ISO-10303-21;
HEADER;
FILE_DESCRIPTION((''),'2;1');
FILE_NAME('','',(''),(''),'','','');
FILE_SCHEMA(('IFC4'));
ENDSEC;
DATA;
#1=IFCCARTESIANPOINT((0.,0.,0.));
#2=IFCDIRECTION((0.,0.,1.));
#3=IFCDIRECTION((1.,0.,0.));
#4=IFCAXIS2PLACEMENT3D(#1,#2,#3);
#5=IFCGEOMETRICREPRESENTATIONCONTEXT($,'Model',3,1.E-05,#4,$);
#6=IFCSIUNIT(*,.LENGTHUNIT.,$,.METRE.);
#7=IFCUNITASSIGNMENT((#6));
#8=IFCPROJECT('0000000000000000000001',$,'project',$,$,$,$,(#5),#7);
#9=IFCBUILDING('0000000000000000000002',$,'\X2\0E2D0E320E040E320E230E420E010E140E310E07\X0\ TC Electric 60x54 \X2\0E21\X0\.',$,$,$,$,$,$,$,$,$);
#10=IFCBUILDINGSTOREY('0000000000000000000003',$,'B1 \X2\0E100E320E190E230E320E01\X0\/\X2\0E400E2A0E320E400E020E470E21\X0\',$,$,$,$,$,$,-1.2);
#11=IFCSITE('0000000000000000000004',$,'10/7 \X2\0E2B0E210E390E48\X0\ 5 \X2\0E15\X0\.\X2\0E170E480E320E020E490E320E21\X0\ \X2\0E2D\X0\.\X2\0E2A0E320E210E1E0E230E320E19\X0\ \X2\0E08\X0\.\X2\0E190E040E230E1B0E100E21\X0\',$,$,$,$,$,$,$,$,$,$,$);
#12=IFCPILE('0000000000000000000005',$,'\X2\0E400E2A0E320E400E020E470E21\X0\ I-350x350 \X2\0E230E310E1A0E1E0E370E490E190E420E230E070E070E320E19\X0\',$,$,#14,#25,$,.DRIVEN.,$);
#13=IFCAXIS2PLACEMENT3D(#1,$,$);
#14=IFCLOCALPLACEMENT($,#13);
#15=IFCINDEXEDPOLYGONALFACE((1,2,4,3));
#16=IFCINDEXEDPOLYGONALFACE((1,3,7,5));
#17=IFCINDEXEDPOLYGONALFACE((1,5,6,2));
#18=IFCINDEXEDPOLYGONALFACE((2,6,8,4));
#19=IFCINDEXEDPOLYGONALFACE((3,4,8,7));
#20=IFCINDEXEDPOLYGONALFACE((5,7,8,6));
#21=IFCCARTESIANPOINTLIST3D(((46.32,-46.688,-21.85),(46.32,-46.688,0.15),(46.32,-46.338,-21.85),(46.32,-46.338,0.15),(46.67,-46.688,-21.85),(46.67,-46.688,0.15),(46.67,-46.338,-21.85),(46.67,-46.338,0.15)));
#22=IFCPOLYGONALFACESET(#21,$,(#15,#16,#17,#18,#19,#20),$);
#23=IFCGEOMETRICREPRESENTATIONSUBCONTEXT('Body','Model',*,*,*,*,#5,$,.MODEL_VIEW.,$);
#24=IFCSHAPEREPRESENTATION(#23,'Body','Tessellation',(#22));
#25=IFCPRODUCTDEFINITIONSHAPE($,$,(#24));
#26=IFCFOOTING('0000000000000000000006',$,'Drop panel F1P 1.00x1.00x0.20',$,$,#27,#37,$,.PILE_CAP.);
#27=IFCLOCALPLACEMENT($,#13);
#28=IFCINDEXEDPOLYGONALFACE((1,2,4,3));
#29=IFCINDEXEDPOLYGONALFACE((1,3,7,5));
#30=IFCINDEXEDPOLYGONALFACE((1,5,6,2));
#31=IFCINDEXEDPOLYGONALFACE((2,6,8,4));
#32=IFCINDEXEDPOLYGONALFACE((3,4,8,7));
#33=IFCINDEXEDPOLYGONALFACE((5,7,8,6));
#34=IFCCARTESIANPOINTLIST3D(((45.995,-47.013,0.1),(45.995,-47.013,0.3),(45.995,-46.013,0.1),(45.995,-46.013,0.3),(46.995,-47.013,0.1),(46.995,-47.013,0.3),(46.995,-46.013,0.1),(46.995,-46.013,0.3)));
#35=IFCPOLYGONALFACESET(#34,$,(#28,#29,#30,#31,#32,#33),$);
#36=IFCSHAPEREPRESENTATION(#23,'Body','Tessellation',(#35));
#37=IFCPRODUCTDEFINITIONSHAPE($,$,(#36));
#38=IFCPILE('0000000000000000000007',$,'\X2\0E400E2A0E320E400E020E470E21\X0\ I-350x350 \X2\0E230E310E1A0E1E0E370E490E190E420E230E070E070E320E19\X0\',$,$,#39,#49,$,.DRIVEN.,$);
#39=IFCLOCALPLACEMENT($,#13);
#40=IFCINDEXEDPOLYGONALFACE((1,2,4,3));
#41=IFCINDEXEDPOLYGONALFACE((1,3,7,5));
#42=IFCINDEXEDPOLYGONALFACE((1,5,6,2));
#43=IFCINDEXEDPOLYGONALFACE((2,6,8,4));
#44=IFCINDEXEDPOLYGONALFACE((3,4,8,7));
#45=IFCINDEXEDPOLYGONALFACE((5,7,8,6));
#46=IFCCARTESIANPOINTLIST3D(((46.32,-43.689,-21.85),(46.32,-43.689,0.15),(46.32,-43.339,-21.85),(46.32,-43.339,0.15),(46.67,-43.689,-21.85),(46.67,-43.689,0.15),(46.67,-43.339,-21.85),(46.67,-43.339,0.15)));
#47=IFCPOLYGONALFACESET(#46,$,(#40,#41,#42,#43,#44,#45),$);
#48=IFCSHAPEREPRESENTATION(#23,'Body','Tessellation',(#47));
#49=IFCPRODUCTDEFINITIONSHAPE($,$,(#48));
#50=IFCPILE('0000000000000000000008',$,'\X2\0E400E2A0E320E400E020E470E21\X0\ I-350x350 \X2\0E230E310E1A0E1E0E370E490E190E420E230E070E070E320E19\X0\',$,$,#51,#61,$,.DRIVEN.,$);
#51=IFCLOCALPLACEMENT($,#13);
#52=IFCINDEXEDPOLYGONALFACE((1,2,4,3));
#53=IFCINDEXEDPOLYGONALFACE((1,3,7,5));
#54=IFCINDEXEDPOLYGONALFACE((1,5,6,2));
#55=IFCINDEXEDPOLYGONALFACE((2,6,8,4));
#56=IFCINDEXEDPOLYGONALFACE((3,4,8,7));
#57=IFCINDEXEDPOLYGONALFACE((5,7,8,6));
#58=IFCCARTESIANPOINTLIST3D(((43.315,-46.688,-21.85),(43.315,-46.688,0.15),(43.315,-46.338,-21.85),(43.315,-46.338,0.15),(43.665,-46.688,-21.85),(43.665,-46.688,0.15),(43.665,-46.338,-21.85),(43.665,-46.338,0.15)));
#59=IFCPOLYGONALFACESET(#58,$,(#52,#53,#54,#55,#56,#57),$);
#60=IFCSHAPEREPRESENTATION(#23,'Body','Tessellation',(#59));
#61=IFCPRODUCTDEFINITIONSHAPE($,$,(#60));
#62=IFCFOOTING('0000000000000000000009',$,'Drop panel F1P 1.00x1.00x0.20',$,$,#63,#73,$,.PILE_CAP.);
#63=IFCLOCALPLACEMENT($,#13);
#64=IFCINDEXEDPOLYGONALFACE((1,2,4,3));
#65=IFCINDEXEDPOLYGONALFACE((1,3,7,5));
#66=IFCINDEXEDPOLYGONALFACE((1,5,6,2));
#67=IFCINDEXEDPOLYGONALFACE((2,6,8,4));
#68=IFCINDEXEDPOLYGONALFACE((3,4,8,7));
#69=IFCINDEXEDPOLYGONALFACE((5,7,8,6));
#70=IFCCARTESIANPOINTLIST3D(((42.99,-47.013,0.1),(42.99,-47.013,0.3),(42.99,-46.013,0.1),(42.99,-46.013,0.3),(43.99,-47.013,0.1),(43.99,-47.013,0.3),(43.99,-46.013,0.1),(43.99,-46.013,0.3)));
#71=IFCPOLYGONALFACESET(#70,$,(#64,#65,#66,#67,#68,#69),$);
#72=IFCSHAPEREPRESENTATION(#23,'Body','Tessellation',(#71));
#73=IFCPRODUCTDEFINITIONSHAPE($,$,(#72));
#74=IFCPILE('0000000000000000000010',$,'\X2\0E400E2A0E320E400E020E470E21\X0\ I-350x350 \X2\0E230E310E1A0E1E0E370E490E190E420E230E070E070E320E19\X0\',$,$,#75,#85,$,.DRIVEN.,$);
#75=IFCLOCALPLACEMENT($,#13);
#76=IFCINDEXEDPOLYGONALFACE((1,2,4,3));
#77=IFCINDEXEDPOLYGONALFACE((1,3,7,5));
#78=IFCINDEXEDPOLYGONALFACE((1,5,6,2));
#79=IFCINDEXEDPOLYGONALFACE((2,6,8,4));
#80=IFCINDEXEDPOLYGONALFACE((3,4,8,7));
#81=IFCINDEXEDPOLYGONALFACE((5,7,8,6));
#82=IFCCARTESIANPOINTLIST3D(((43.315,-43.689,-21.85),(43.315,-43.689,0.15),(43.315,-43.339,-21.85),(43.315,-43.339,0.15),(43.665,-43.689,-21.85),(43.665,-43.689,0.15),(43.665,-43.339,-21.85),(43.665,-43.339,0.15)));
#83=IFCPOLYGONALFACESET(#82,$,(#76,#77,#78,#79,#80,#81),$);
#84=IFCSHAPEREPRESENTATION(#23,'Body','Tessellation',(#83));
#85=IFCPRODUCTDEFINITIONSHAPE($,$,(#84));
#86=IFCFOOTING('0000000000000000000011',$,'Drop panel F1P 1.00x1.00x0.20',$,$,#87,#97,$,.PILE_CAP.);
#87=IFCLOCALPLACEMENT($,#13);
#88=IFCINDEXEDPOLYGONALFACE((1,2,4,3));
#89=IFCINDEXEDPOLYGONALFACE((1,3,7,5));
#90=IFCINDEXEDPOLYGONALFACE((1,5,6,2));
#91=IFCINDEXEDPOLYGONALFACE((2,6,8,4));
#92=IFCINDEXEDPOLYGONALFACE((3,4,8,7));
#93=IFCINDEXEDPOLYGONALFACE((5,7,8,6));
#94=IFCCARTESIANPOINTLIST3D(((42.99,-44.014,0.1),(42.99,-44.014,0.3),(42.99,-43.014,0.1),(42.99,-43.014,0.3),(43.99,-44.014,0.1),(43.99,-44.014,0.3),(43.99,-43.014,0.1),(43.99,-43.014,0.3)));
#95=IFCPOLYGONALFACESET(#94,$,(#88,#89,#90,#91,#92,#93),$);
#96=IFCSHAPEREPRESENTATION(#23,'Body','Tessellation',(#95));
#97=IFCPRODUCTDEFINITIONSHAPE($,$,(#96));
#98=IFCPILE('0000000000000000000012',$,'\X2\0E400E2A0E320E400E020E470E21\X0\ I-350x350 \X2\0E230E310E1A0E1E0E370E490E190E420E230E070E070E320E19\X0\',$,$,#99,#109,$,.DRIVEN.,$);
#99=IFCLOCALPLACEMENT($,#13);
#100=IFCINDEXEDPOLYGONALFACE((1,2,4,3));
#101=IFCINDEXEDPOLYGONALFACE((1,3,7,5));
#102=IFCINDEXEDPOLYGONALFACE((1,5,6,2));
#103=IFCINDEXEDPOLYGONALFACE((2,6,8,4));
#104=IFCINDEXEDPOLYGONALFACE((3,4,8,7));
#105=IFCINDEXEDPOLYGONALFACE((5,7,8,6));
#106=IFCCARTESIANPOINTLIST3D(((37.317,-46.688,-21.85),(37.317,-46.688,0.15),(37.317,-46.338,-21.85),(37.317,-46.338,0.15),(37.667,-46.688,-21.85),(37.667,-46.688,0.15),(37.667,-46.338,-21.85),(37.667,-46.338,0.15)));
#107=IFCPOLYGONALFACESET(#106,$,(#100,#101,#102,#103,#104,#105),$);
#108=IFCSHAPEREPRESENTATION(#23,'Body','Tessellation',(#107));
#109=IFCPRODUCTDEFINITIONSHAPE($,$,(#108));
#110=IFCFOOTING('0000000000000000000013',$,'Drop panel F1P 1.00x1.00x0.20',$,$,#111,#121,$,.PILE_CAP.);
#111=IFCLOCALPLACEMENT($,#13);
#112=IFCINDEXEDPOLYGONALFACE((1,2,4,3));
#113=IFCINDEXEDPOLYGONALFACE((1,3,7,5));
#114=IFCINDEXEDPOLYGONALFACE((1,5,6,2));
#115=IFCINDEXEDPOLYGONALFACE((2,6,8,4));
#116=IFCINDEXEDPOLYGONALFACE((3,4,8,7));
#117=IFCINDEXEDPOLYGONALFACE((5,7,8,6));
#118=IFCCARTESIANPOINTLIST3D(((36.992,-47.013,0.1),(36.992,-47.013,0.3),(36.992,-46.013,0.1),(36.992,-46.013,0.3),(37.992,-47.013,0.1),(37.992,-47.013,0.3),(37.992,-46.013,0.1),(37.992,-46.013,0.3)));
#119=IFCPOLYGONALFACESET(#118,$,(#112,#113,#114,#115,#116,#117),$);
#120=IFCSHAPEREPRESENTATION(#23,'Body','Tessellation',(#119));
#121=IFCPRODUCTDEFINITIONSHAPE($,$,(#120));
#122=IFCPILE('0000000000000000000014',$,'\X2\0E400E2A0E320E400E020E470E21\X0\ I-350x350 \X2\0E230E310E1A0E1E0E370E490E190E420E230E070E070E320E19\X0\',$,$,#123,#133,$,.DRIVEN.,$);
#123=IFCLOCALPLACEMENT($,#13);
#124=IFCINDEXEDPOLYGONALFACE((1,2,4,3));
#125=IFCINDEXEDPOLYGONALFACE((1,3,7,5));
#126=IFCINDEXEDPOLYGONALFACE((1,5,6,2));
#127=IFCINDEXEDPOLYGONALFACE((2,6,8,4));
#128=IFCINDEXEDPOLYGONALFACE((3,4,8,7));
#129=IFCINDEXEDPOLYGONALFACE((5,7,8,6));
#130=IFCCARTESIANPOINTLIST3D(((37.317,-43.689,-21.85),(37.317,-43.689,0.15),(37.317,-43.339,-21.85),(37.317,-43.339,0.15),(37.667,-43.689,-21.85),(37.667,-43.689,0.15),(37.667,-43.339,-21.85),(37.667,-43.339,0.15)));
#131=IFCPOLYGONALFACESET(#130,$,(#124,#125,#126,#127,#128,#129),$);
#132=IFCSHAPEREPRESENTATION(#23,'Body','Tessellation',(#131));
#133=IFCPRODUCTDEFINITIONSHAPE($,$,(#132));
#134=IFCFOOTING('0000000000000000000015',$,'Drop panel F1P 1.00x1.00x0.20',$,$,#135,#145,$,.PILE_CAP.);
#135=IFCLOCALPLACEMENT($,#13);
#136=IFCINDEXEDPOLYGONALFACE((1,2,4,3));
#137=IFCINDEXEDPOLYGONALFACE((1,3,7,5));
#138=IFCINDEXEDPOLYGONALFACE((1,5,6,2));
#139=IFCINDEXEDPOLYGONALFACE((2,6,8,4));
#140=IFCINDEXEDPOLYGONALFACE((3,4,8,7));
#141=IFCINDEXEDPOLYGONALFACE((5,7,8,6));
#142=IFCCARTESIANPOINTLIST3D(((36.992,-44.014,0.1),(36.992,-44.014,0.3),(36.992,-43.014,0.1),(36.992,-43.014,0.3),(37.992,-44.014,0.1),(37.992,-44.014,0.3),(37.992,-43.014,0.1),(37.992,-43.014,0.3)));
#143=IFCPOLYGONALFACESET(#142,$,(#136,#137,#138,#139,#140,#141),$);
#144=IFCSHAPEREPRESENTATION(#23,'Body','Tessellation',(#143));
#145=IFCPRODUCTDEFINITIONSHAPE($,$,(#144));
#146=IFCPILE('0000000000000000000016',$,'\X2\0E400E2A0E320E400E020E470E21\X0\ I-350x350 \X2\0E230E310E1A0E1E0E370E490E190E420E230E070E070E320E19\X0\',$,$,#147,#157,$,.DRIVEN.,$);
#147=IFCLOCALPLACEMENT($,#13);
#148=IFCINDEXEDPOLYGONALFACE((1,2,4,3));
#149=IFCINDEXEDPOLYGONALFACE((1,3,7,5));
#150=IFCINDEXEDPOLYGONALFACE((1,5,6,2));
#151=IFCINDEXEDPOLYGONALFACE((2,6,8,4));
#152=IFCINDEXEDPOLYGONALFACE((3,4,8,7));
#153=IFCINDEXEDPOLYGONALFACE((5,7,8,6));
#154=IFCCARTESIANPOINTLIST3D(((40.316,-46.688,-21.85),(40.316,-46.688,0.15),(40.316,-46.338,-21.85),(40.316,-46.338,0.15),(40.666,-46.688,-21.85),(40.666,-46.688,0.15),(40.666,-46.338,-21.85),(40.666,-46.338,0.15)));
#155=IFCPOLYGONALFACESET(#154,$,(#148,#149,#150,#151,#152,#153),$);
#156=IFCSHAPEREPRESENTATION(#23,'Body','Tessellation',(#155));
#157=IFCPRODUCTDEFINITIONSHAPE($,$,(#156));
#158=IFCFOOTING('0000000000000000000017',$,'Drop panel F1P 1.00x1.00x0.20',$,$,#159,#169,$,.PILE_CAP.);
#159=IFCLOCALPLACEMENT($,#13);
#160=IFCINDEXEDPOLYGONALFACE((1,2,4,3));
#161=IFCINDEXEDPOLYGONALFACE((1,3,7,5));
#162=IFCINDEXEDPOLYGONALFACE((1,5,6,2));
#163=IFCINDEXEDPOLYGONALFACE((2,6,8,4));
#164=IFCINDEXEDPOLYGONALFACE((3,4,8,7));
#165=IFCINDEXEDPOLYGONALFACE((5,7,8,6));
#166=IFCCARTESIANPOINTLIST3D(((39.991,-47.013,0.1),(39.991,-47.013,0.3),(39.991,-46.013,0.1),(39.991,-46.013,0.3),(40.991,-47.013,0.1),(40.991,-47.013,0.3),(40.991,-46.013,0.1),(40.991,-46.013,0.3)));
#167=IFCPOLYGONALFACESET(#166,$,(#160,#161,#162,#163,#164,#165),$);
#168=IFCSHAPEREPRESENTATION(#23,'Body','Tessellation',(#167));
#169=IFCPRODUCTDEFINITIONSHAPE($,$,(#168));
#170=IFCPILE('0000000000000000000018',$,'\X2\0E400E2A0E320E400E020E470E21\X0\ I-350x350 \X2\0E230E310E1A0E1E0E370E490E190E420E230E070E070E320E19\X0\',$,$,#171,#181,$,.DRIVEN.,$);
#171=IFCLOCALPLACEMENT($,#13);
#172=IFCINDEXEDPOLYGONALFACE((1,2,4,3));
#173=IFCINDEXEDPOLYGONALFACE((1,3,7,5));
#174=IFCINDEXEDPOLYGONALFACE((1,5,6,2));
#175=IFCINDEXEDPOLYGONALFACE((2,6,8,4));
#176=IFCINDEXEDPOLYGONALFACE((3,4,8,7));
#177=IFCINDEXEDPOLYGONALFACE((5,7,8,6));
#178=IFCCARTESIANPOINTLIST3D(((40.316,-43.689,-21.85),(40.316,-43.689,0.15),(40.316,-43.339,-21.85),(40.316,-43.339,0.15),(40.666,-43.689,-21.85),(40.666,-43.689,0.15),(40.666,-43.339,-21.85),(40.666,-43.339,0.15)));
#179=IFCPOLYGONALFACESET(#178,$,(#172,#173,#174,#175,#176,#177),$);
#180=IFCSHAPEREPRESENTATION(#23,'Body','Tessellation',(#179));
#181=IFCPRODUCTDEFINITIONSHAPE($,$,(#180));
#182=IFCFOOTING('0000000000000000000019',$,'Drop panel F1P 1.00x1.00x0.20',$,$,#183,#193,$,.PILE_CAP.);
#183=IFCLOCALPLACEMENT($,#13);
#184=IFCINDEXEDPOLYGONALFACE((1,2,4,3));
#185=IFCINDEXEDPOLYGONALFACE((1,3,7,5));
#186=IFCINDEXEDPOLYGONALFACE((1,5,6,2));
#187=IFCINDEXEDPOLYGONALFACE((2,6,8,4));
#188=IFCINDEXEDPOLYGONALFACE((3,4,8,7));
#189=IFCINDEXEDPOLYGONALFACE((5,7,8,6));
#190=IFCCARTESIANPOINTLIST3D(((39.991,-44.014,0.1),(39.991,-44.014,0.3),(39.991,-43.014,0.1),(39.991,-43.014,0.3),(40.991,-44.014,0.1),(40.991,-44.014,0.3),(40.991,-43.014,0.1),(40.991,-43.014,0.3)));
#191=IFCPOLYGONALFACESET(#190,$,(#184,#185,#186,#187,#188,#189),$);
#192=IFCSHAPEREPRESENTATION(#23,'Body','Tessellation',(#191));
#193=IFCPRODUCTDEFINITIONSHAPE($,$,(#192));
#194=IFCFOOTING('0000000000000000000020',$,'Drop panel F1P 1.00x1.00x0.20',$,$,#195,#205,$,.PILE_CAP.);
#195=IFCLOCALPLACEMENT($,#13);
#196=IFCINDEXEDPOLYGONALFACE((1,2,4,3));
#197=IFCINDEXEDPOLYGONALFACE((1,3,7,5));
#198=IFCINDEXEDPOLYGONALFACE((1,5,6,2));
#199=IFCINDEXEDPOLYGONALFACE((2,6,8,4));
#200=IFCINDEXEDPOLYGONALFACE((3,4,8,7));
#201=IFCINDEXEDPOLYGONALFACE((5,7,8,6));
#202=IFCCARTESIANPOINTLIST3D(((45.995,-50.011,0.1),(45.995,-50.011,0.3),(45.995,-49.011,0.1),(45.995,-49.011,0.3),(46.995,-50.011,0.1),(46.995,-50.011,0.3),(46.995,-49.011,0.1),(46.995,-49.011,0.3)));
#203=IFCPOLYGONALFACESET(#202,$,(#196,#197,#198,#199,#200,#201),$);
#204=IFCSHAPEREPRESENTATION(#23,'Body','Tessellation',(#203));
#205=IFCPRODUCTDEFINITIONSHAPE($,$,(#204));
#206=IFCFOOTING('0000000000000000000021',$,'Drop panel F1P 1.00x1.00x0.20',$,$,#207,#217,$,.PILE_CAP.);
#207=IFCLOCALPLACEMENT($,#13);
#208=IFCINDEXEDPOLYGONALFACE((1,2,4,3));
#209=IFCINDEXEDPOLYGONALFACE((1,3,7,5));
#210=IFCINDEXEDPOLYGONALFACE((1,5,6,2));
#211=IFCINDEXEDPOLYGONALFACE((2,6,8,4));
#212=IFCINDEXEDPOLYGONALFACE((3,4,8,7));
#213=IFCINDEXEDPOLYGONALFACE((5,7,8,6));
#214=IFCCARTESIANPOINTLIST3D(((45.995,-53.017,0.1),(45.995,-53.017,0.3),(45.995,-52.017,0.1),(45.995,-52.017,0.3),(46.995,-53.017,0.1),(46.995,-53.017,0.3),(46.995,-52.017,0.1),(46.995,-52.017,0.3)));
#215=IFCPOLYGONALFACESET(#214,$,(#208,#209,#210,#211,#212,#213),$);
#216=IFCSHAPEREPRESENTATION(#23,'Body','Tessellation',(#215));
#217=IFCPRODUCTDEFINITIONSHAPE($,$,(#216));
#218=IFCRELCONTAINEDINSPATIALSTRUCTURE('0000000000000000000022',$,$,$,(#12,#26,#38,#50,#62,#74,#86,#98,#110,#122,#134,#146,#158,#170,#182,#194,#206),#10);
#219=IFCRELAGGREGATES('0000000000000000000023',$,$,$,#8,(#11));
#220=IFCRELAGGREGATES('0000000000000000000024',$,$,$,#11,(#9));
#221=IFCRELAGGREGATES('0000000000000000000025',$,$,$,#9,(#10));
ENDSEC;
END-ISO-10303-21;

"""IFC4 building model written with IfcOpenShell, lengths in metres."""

from ifc_helpers import new_model, si_unit, frame, origin, origin_with_axes, origin_2d, place, context, subcontext, project, spatial, rectangle, extrude, element, save


model = new_model("IFC4")

# Units and contexts
model_context = context("Model", 3, precision=1e-05, world=origin_with_axes())
body_context = subcontext(model_context, "Body", "Model", "MODEL_VIEW")
ifc_project = project(units=[si_unit("LENGTHUNIT", "METRE")], contexts=[model_context])

# Site, building, storey
site = spatial("IfcSite", under=ifc_project, Name="10/7 หมู่ 5 ต.ท่าข้าม อ.สามพราน จ.นครปฐม")
building = spatial("IfcBuilding", under=site, Name="อาคารโกดัง TC Electric 60x54 ม.")
storey = spatial("IfcBuildingStorey", under=building, Name="B1 ฐานราก/เสาเข็ม", Elevation=-1.2)

# Pile
pile_1_placement = place(None, frame((46.495, -46.513, -21.85), z_axis=(0.0, 0.0, 1.0), x_axis=(1.0, 0.0, 0.0)))
element("IfcPile", 1, at=pile_1_placement, inside=storey, Name="เสาเข็ม I-350x350 รับพื้นโรงงาน", PredefinedType="DRIVEN", context=body_context, shape_type="SweptSolid", body=[
    extrude(rectangle(XDim=0.35, YDim=0.35, at=origin_2d()), origin(), (0.0, 0.0, 1.0), 22.0),
])

# Footing
footing_1_placement = place(None, frame((46.495, -46.513, 0.1), z_axis=(0.0, 0.0, 1.0), x_axis=(1.0, 0.0, 0.0)))
element("IfcFooting", 2, at=footing_1_placement, inside=storey, Name="Drop panel F1P 1.00x1.00x0.20", PredefinedType="PILE_CAP", context=body_context, shape_type="SweptSolid", body=[
    extrude(rectangle(XDim=1.0, YDim=1.0, at=origin_2d()), origin(), (0.0, 0.0, 1.0), 0.2),
])

# Piles
for number, where, z_axis, x_axis, name in (
    (3, (46.495, -43.514, -21.85), (0.0, 0.0, 1.0), (1.0, 0.0, 0.0), "เสาเข็ม I-350x350 รับพื้นโรงงาน"),
    (4, (43.49, -46.513, -21.85), (0.0, 0.0, 1.0), (1.0, 0.0, 0.0), "เสาเข็ม I-350x350 รับพื้นโรงงาน"),
):
    element("IfcPile", number, at=place(None, frame(where, z_axis=z_axis, x_axis=x_axis)), inside=storey, Name=name, PredefinedType="DRIVEN", context=body_context, shape_type="SweptSolid", body=[
        extrude(rectangle(XDim=0.35, YDim=0.35, at=origin_2d()), origin(), (0.0, 0.0, 1.0), 22.0),
    ])

# Footing
footing_2_placement = place(None, frame((43.49, -46.513, 0.1), z_axis=(0.0, 0.0, 1.0), x_axis=(1.0, 0.0, 0.0)))
element("IfcFooting", 5, at=footing_2_placement, inside=storey, Name="Drop panel F1P 1.00x1.00x0.20", PredefinedType="PILE_CAP", context=body_context, shape_type="SweptSolid", body=[
    extrude(rectangle(XDim=1.0, YDim=1.0, at=origin_2d()), origin(), (0.0, 0.0, 1.0), 0.2),
])

# Pile
pile_2_placement = place(None, frame((43.49, -43.514, -21.85), z_axis=(0.0, 0.0, 1.0), x_axis=(1.0, 0.0, 0.0)))
element("IfcPile", 6, at=pile_2_placement, inside=storey, Name="เสาเข็ม I-350x350 รับพื้นโรงงาน", PredefinedType="DRIVEN", context=body_context, shape_type="SweptSolid", body=[
    extrude(rectangle(XDim=0.35, YDim=0.35, at=origin_2d()), origin(), (0.0, 0.0, 1.0), 22.0),
])

# Footing
footing_3_placement = place(None, frame((43.49, -43.514, 0.1), z_axis=(0.0, 0.0, 1.0), x_axis=(1.0, 0.0, 0.0)))
element("IfcFooting", 7, at=footing_3_placement, inside=storey, Name="Drop panel F1P 1.00x1.00x0.20", PredefinedType="PILE_CAP", context=body_context, shape_type="SweptSolid", body=[
    extrude(rectangle(XDim=1.0, YDim=1.0, at=origin_2d()), origin(), (0.0, 0.0, 1.0), 0.2),
])

# Pile
pile_3_placement = place(None, frame((37.492, -46.513, -21.85), z_axis=(0.0, 0.0, 1.0), x_axis=(1.0, 0.0, 0.0)))
element("IfcPile", 8, at=pile_3_placement, inside=storey, Name="เสาเข็ม I-350x350 รับพื้นโรงงาน", PredefinedType="DRIVEN", context=body_context, shape_type="SweptSolid", body=[
    extrude(rectangle(XDim=0.35, YDim=0.35, at=origin_2d()), origin(), (0.0, 0.0, 1.0), 22.0),
])

# Footing
footing_4_placement = place(None, frame((37.492, -46.513, 0.1), z_axis=(0.0, 0.0, 1.0), x_axis=(1.0, 0.0, 0.0)))
element("IfcFooting", 9, at=footing_4_placement, inside=storey, Name="Drop panel F1P 1.00x1.00x0.20", PredefinedType="PILE_CAP", context=body_context, shape_type="SweptSolid", body=[
    extrude(rectangle(XDim=1.0, YDim=1.0, at=origin_2d()), origin(), (0.0, 0.0, 1.0), 0.2),
])

# Pile
pile_4_placement = place(None, frame((37.492, -43.514, -21.85), z_axis=(0.0, 0.0, 1.0), x_axis=(1.0, 0.0, 0.0)))
element("IfcPile", 10, at=pile_4_placement, inside=storey, Name="เสาเข็ม I-350x350 รับพื้นโรงงาน", PredefinedType="DRIVEN", context=body_context, shape_type="SweptSolid", body=[
    extrude(rectangle(XDim=0.35, YDim=0.35, at=origin_2d()), origin(), (0.0, 0.0, 1.0), 22.0),
])

# Footing
footing_5_placement = place(None, frame((37.492, -43.514, 0.1), z_axis=(0.0, 0.0, 1.0), x_axis=(1.0, 0.0, 0.0)))
element("IfcFooting", 11, at=footing_5_placement, inside=storey, Name="Drop panel F1P 1.00x1.00x0.20", PredefinedType="PILE_CAP", context=body_context, shape_type="SweptSolid", body=[
    extrude(rectangle(XDim=1.0, YDim=1.0, at=origin_2d()), origin(), (0.0, 0.0, 1.0), 0.2),
])

# Pile
pile_5_placement = place(None, frame((40.491, -46.513, -21.85), z_axis=(0.0, 0.0, 1.0), x_axis=(1.0, 0.0, 0.0)))
element("IfcPile", 12, at=pile_5_placement, inside=storey, Name="เสาเข็ม I-350x350 รับพื้นโรงงาน", PredefinedType="DRIVEN", context=body_context, shape_type="SweptSolid", body=[
    extrude(rectangle(XDim=0.35, YDim=0.35, at=origin_2d()), origin(), (0.0, 0.0, 1.0), 22.0),
])

# Footing
footing_6_placement = place(None, frame((40.491, -46.513, 0.1), z_axis=(0.0, 0.0, 1.0), x_axis=(1.0, 0.0, 0.0)))
element("IfcFooting", 13, at=footing_6_placement, inside=storey, Name="Drop panel F1P 1.00x1.00x0.20", PredefinedType="PILE_CAP", context=body_context, shape_type="SweptSolid", body=[
    extrude(rectangle(XDim=1.0, YDim=1.0, at=origin_2d()), origin(), (0.0, 0.0, 1.0), 0.2),
])

# Pile
pile_6_placement = place(None, frame((40.491, -43.514, -21.85), z_axis=(0.0, 0.0, 1.0), x_axis=(1.0, 0.0, 0.0)))
element("IfcPile", 14, at=pile_6_placement, inside=storey, Name="เสาเข็ม I-350x350 รับพื้นโรงงาน", PredefinedType="DRIVEN", context=body_context, shape_type="SweptSolid", body=[
    extrude(rectangle(XDim=0.35, YDim=0.35, at=origin_2d()), origin(), (0.0, 0.0, 1.0), 22.0),
])

# Footings
for number, where, z_axis, x_axis, name in (
    (15, (40.491, -43.514, 0.1), (0.0, 0.0, 1.0), (1.0, 0.0, 0.0), "Drop panel F1P 1.00x1.00x0.20"),
    (16, (46.495, -49.511, 0.1), (0.0, 0.0, 1.0), (1.0, 0.0, 0.0), "Drop panel F1P 1.00x1.00x0.20"),
    (17, (46.495, -52.517, 0.1), (0.0, 0.0, 1.0), (1.0, 0.0, 0.0), "Drop panel F1P 1.00x1.00x0.20"),
):
    element("IfcFooting", number, at=place(None, frame(where, z_axis=z_axis, x_axis=x_axis)), inside=storey, Name=name, PredefinedType="PILE_CAP", context=body_context, shape_type="SweptSolid", body=[
        extrude(rectangle(XDim=1.0, YDim=1.0, at=origin_2d()), origin(), (0.0, 0.0, 1.0), 0.2),
    ])

save(model, "model.ifc")
